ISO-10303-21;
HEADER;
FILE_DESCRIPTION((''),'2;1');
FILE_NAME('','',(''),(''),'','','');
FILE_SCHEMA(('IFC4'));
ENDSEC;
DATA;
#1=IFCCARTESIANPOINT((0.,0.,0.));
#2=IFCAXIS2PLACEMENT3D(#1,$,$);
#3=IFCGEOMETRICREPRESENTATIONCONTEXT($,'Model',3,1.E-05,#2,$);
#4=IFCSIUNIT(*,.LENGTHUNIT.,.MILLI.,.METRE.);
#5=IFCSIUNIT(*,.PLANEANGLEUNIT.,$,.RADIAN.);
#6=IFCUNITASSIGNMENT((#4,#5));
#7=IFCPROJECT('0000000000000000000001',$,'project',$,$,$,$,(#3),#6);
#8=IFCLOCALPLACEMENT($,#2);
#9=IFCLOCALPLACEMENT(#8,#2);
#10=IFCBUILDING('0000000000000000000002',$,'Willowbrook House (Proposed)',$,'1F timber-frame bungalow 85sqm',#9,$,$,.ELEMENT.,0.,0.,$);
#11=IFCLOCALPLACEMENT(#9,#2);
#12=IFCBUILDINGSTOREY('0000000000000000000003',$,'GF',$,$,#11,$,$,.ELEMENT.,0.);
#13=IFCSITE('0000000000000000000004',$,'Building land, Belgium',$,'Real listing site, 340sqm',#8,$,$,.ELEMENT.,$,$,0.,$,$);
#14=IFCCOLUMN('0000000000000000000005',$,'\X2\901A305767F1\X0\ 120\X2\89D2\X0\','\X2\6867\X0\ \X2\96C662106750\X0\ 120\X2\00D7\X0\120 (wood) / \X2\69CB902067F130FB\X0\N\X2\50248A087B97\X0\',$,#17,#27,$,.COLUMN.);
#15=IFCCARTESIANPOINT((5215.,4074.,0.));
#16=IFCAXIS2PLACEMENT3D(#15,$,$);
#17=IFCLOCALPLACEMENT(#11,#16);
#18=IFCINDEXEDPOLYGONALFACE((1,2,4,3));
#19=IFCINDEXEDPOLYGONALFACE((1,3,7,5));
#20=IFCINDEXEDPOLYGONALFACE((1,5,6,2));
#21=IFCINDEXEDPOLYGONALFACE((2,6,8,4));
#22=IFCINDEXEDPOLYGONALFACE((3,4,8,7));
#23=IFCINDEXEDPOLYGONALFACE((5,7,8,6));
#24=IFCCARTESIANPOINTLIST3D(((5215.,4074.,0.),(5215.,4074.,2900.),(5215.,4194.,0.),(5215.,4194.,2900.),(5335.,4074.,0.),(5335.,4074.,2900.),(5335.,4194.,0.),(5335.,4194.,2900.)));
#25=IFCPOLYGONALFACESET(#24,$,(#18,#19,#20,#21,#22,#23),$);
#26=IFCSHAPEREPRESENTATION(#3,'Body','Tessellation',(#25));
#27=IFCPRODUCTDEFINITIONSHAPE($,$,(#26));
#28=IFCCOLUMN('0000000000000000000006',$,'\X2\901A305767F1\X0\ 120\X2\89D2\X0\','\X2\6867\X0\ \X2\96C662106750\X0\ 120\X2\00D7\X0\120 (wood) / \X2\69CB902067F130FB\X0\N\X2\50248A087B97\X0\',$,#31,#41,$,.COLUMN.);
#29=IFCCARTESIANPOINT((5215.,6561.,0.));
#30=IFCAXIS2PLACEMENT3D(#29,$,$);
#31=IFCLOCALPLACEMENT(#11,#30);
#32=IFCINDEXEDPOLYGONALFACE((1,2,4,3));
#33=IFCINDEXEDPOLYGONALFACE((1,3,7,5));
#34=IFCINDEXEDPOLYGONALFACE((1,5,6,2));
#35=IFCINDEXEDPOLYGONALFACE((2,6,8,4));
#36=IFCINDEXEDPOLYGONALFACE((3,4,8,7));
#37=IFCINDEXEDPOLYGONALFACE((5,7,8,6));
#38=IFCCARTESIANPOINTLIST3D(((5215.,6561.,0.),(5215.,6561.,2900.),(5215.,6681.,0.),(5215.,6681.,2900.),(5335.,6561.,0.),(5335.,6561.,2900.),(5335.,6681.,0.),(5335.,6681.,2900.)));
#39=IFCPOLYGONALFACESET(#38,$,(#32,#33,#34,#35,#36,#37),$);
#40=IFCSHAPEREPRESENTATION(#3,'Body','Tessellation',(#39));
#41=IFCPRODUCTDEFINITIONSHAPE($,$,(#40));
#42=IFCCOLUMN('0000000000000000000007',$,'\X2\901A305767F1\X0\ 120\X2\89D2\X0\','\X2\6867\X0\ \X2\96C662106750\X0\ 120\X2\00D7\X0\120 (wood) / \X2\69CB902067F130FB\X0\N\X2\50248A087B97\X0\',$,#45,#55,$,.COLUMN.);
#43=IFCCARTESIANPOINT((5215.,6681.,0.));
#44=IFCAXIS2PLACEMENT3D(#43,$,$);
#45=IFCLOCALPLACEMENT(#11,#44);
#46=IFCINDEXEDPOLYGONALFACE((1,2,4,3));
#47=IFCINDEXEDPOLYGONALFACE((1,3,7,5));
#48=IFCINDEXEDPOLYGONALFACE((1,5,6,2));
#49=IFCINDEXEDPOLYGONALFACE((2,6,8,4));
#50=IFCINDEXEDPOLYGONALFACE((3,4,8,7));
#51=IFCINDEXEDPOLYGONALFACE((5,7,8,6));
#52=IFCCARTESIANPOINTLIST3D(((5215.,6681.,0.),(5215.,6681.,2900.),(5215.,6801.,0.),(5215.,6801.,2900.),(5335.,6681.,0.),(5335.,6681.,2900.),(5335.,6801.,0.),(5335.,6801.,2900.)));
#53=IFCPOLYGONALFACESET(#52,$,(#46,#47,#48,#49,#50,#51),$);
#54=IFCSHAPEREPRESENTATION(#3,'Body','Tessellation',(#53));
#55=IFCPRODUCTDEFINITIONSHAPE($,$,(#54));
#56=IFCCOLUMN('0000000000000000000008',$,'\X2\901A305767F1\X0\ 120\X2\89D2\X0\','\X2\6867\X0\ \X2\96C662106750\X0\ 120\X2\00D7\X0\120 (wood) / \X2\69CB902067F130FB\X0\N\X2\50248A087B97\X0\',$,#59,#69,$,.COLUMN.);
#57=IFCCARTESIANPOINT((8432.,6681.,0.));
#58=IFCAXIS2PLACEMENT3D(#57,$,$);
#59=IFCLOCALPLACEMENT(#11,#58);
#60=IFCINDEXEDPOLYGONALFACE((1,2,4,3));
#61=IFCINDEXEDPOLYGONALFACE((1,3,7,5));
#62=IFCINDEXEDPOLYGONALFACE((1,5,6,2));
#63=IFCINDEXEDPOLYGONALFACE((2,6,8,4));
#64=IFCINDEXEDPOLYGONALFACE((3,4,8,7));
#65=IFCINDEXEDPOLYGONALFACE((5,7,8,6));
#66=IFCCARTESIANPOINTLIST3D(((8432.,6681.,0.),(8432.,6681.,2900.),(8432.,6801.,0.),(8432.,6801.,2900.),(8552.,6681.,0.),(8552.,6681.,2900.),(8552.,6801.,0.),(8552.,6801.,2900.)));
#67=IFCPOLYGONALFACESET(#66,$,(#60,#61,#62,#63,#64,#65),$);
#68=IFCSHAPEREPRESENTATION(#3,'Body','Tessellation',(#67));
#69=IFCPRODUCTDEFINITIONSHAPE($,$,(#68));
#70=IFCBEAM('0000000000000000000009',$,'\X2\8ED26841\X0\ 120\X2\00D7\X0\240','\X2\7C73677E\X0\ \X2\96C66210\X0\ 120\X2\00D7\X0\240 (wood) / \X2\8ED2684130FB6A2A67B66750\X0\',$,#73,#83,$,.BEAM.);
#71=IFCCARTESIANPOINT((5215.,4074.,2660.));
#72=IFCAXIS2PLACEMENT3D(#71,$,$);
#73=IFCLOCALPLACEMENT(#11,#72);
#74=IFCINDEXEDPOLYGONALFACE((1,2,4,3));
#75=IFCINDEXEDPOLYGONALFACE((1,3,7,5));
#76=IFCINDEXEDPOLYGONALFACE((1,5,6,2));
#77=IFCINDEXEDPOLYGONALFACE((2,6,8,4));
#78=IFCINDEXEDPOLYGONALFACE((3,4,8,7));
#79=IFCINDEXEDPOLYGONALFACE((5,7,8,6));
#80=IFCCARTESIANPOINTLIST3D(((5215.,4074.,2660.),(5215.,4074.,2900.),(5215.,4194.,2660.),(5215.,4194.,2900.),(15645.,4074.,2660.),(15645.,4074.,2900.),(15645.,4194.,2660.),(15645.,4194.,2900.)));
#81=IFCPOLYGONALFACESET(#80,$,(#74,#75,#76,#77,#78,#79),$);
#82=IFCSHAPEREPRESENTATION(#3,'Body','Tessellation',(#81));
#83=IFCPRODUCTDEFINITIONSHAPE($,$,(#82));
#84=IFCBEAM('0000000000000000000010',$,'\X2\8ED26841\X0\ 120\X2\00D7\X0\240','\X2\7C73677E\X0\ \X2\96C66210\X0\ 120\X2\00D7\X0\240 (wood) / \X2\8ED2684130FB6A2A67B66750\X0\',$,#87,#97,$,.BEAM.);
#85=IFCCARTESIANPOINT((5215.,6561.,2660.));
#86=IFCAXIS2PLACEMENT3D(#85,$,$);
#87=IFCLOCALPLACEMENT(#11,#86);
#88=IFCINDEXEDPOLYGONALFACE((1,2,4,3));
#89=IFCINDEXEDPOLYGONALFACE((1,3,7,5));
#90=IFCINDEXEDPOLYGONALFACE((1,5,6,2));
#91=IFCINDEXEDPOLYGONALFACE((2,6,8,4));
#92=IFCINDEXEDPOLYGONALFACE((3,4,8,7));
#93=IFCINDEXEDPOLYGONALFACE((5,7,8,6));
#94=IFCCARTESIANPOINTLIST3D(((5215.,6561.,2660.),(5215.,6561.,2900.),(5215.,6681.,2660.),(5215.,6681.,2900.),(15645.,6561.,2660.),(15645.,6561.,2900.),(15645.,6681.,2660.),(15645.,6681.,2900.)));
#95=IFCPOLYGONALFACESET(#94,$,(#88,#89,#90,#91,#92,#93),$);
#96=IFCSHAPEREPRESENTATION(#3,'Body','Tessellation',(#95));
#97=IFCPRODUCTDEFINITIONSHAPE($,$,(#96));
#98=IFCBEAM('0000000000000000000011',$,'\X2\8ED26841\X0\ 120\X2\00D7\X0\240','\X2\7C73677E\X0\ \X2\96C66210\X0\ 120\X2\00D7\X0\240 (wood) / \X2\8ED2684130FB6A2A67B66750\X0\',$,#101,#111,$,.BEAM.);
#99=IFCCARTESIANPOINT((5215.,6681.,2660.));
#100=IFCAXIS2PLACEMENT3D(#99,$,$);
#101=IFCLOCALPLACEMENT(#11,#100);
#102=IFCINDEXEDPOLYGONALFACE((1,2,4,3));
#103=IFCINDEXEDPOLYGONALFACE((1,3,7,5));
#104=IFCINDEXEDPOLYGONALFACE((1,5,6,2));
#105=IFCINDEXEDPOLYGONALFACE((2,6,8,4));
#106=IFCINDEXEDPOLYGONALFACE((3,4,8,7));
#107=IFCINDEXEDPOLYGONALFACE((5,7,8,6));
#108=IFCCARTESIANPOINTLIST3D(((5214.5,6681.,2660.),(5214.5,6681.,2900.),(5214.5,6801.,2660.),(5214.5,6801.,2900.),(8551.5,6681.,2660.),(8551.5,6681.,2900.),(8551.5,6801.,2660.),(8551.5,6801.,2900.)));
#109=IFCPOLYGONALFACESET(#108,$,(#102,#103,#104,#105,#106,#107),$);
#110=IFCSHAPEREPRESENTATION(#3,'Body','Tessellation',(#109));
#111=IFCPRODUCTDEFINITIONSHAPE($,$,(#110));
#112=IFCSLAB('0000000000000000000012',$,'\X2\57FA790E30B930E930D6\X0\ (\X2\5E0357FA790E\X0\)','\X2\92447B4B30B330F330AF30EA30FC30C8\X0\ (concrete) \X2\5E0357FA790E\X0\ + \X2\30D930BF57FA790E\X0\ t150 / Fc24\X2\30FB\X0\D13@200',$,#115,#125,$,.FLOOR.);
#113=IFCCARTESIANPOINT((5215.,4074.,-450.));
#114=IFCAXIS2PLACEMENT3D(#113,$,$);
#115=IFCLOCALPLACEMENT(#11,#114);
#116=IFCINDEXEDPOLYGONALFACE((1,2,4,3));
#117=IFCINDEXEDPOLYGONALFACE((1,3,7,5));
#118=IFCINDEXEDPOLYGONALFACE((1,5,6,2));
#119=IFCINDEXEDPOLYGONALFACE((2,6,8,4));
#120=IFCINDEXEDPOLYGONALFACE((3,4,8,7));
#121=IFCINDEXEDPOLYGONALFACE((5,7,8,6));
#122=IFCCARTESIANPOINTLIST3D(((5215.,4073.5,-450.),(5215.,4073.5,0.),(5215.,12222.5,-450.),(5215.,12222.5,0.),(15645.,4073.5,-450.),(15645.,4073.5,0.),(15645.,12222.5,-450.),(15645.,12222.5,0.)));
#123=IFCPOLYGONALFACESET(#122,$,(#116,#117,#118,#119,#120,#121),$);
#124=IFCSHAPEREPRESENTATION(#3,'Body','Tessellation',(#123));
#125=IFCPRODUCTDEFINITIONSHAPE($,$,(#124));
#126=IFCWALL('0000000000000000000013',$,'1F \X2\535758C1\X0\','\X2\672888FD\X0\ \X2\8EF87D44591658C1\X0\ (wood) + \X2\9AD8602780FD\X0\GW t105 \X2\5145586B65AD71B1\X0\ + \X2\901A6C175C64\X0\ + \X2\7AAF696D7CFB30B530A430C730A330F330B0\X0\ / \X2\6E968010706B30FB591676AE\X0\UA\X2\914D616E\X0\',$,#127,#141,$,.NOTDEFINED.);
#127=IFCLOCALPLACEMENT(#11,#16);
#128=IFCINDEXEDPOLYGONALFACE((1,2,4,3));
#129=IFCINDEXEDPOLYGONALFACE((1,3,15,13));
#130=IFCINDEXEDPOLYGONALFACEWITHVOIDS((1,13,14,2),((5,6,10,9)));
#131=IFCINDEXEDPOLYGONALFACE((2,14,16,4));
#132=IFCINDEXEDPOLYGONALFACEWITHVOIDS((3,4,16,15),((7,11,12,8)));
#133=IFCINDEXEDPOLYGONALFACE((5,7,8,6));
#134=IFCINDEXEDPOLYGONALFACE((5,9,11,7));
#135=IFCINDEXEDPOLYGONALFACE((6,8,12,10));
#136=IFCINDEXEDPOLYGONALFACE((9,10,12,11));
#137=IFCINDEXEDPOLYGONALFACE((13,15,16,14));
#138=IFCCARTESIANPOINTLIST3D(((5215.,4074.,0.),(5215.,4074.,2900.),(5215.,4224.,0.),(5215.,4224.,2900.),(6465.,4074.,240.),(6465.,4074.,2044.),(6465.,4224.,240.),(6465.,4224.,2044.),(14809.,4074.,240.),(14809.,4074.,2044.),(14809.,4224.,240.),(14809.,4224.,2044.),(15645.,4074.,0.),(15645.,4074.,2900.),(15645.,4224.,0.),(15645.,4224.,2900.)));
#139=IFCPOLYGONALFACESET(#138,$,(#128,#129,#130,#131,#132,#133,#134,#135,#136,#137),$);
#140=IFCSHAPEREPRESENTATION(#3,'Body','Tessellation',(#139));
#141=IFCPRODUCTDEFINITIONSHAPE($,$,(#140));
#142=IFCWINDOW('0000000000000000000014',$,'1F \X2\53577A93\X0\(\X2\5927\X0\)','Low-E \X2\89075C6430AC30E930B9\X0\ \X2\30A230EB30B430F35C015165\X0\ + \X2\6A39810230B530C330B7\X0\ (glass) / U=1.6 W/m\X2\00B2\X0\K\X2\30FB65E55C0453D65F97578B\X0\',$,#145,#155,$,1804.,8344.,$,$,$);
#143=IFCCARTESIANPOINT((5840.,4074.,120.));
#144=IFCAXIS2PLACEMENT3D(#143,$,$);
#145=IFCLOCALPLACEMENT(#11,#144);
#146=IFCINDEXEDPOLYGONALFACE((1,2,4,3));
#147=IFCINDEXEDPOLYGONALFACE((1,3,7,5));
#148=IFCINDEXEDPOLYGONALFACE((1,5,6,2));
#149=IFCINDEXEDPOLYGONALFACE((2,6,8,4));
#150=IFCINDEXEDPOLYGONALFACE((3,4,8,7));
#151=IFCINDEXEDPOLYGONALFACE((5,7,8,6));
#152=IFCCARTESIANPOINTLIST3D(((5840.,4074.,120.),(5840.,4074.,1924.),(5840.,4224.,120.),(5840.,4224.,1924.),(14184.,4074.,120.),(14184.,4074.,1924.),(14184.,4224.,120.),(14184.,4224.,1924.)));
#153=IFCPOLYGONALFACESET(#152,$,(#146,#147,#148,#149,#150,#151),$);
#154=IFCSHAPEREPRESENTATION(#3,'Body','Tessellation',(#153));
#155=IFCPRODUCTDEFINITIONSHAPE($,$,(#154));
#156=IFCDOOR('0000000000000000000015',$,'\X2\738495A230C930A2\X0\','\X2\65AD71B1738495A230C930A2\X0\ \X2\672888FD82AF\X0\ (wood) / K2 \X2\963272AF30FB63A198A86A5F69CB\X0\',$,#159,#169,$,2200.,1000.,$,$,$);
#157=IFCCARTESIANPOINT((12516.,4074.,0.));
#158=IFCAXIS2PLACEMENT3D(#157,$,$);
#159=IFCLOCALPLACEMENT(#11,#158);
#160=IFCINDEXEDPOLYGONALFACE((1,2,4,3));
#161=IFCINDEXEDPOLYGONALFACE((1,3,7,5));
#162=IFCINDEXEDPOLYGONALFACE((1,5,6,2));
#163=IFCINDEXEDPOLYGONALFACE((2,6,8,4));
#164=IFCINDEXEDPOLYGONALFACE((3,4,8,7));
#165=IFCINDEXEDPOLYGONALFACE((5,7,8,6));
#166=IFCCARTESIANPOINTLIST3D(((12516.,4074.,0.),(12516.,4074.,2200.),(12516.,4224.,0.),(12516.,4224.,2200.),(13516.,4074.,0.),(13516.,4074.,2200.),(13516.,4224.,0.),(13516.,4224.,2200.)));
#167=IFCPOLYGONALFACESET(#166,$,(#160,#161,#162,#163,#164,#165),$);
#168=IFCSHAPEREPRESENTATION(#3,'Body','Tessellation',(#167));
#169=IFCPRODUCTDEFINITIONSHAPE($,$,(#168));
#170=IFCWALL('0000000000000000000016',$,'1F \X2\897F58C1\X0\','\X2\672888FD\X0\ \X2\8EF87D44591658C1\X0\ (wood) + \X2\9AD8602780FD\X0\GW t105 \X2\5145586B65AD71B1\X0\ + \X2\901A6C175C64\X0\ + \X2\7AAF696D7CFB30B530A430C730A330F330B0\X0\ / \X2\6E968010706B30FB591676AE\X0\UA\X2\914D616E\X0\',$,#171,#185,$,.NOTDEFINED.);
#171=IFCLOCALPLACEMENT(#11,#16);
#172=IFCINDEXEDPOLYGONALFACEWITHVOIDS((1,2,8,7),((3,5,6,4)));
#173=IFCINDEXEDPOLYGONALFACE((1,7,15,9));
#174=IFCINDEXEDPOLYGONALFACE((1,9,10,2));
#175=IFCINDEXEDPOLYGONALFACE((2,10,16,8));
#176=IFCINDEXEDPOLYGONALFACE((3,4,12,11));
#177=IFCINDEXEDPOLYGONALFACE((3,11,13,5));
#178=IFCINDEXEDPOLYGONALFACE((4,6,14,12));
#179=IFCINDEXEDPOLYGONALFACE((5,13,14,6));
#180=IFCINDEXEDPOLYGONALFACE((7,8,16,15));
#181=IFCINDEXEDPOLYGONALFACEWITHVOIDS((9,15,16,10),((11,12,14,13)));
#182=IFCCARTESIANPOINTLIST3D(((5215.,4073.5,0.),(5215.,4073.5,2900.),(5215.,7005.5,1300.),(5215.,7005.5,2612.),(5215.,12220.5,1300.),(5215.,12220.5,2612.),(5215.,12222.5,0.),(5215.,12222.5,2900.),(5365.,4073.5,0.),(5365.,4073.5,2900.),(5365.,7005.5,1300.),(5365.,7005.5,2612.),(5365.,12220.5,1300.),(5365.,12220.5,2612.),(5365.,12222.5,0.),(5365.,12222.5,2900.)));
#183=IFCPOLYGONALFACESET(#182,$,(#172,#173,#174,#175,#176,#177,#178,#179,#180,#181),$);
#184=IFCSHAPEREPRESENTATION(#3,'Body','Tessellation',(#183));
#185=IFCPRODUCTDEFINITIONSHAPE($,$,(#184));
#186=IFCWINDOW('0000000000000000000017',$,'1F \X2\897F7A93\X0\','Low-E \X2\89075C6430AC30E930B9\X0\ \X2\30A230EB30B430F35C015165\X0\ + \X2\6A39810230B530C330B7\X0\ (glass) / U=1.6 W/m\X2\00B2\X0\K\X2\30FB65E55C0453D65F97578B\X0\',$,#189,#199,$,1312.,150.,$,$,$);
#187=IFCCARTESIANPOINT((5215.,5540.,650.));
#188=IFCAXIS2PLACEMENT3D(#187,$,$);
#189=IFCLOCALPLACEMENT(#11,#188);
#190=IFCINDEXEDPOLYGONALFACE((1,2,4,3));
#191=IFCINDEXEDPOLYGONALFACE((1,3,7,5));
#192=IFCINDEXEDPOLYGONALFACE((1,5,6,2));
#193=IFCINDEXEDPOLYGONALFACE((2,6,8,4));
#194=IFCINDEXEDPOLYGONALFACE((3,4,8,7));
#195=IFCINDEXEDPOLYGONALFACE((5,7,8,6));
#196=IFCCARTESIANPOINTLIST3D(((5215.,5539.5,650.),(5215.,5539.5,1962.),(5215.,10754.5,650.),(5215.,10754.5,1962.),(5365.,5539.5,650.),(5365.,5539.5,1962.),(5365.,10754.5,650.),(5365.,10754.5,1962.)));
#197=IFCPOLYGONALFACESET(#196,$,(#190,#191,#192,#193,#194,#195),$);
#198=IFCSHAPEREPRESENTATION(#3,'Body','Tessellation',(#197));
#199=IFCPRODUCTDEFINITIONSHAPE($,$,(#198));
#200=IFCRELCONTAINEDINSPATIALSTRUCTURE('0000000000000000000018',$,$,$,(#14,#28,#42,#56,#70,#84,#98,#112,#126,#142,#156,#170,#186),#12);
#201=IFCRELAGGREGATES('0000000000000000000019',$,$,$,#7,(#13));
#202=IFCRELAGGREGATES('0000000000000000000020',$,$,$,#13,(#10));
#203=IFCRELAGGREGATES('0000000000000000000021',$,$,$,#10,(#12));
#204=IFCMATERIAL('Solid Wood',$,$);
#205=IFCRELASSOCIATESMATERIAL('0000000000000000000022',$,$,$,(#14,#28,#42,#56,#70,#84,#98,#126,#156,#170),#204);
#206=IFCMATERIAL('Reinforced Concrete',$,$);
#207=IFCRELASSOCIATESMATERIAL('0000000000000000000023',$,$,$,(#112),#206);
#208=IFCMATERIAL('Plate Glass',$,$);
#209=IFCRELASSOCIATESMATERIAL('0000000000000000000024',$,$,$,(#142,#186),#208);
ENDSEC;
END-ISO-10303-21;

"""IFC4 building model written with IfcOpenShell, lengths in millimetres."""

from ifc_helpers import new_model, si_unit, frame, frame_2d, origin, place, context, project, spatial, rectangle, extrude, material, element, fill, save


model = new_model("IFC4")

# Units and contexts
model_context = context("Model", 3, precision=1e-05, world=origin())
ifc_project = project(units=[si_unit("LENGTHUNIT", "METRE", prefix="MILLI"), si_unit("PLANEANGLEUNIT", "RADIAN")], contexts=[model_context])

# Site, building, storey
site_placement = place(None, origin())
site = spatial("IfcSite", under=ifc_project, at=site_placement, Name="Building land, Belgium", ObjectType="Real listing site, 340sqm", CompositionType="ELEMENT", RefElevation=0.0)
building_placement = place(site_placement, origin())
building = spatial("IfcBuilding", under=site, at=building_placement, Name="Willowbrook House (Proposed)", ObjectType="1F timber-frame bungalow 85sqm", CompositionType="ELEMENT", ElevationOfRefHeight=0.0, ElevationOfTerrain=0.0)
storey_placement = place(building_placement, origin())
storey = spatial("IfcBuildingStorey", under=building, at=storey_placement, Name="GF", CompositionType="ELEMENT", Elevation=0.0)

# Columns
ifc_material_1 = material(Name="Solid Wood")
column_1_placement = place(storey_placement, frame((5215.0, 4074.0, 0.0)))
element("IfcColumn", 1, at=column_1_placement, inside=storey, material=ifc_material_1, Name="通し柱 120角", Description="桧 集成材 120×120 (wood) / 構造柱・N値計算", PredefinedType="COLUMN", context=model_context, shape_type="SweptSolid", body=[
    extrude(rectangle(XDim=120.0, YDim=120.0, at=frame_2d((60.0, 60.0))), frame((5215.0, 4074.0, 0.0)), (0.0, 0.0, 1.0), 2900.0),
])
column_2_placement = place(storey_placement, frame((5215.0, 6561.0, 0.0)))
element("IfcColumn", 2, at=column_2_placement, inside=storey, material=ifc_material_1, Name="通し柱 120角", Description="桧 集成材 120×120 (wood) / 構造柱・N値計算", PredefinedType="COLUMN", context=model_context, shape_type="SweptSolid", body=[
    extrude(rectangle(XDim=120.0, YDim=120.0, at=frame_2d((60.0, 60.0))), frame((5215.0, 6561.0, 0.0)), (0.0, 0.0, 1.0), 2900.0),
])
column_3_placement = place(storey_placement, frame((5215.0, 6681.0, 0.0)))
element("IfcColumn", 3, at=column_3_placement, inside=storey, material=ifc_material_1, Name="通し柱 120角", Description="桧 集成材 120×120 (wood) / 構造柱・N値計算", PredefinedType="COLUMN", context=model_context, shape_type="SweptSolid", body=[
    extrude(rectangle(XDim=120.0, YDim=120.0, at=frame_2d((60.0, 60.0))), frame((5215.0, 6681.0, 0.0)), (0.0, 0.0, 1.0), 2900.0),
])
column_4_placement = place(storey_placement, frame((8432.0, 6681.0, 0.0)))
element("IfcColumn", 4, at=column_4_placement, inside=storey, material=ifc_material_1, Name="通し柱 120角", Description="桧 集成材 120×120 (wood) / 構造柱・N値計算", PredefinedType="COLUMN", context=model_context, shape_type="SweptSolid", body=[
    extrude(rectangle(XDim=120.0, YDim=120.0, at=frame_2d((60.0, 60.0))), frame((8432.0, 6681.0, 0.0)), (0.0, 0.0, 1.0), 2900.0),
])

# Beams
beam_1_placement = place(storey_placement, frame((5215.0, 4074.0, 2660.0)))
element("IfcBeam", 5, at=beam_1_placement, inside=storey, material=ifc_material_1, Name="軒桁 120×240", Description="米松 集成 120×240 (wood) / 軒桁・横架材", PredefinedType="BEAM", context=model_context, shape_type="SweptSolid", body=[
    extrude(rectangle(XDim=10430.0, YDim=120.0, at=frame_2d((5215.0, 60.0))), frame((5215.0, 4074.0, 2660.0)), (0.0, 0.0, 1.0), 240.0),
])
beam_2_placement = place(storey_placement, frame((5215.0, 6561.0, 2660.0)))
element("IfcBeam", 6, at=beam_2_placement, inside=storey, material=ifc_material_1, Name="軒桁 120×240", Description="米松 集成 120×240 (wood) / 軒桁・横架材", PredefinedType="BEAM", context=model_context, shape_type="SweptSolid", body=[
    extrude(rectangle(XDim=10430.0, YDim=120.0, at=frame_2d((5215.0, 60.0))), frame((5215.0, 6561.0, 2660.0)), (0.0, 0.0, 1.0), 240.0),
])
beam_3_placement = place(storey_placement, frame((5215.0, 6681.0, 2660.0)))
element("IfcBeam", 7, at=beam_3_placement, inside=storey, material=ifc_material_1, Name="軒桁 120×240", Description="米松 集成 120×240 (wood) / 軒桁・横架材", PredefinedType="BEAM", context=model_context, shape_type="SweptSolid", body=[
    extrude(rectangle(XDim=3337.0, YDim=120.0, at=frame_2d((1668.0, 60.0))), frame((5215.0, 6681.0, 2660.0)), (0.0, 0.0, 1.0), 240.0),
])

# Slab
ifc_material_2 = material(Name="Reinforced Concrete")
slab_1_placement = place(storey_placement, frame((5215.0, 4074.0, -450.0)))
element("IfcSlab", 8, at=slab_1_placement, inside=storey, material=ifc_material_2, Name="基礎スラブ (布基礎)", Description="鉄筋コンクリート (concrete) 布基礎 + ベタ基礎 t150 / Fc24・D13@200", PredefinedType="FLOOR", context=model_context, shape_type="SweptSolid", body=[
    extrude(rectangle(XDim=10430.0, YDim=8149.0, at=frame_2d((5215.0, 4074.0))), frame((5215.0, 4074.0, -450.0)), (0.0, 0.0, 1.0), 450.0),
])

# Wall, openings, window, door
wall_1_placement = place(storey_placement, frame((5215.0, 4074.0, 0.0)))
wall_1 = element("IfcWall", 9, at=wall_1_placement, inside=storey, material=ifc_material_1, Name="1F 南壁", Description="木製 軸組外壁 (wood) + 高性能GW t105 充填断熱 + 通気層 + 窯業系サイディング / 準耐火・外皮UA配慮", PredefinedType="NOTDEFINED", context=model_context, shape_type="SweptSolid", body=[
    extrude(rectangle(XDim=10430.0, YDim=150.0, at=frame_2d((5215.0, 75.0))), frame((5215.0, 4074.0, 0.0)), (0.0, 0.0, 1.0), 2900.0),
])
opening_1_placement = place(storey_placement, frame((5840.0, 4074.0, 120.0)))
opening_1 = element("IfcOpeningElement", 10, at=opening_1_placement, cuts=wall_1, PredefinedType="NOTDEFINED", context=model_context, shape_type="SweptSolid", body=[
    extrude(rectangle(XDim=8344.0, YDim=150.0, at=frame_2d((4172.0, 75.0))), frame((5840.0, 4074.0, 120.0)), (0.0, 0.0, 1.0), 1804.0),
])
opening_2_placement = place(storey_placement, frame((12516.0, 4074.0, 0.0)))
opening_2 = element("IfcOpeningElement", 11, at=opening_2_placement, cuts=wall_1, PredefinedType="NOTDEFINED", context=model_context, shape_type="SweptSolid", body=[
    extrude(rectangle(XDim=1000.0, YDim=150.0, at=frame_2d((500.0, 75.0))), frame((12516.0, 4074.0, 0.0)), (0.0, 0.0, 1.0), 2200.0),
])
ifc_material_3 = material(Name="Plate Glass")
window_1_placement = place(storey_placement, frame((5840.0, 4074.0, 120.0)))
window_1 = element("IfcWindow", 12, at=window_1_placement, inside=storey, material=ifc_material_3, Name="1F 南窓(大)", Description="Low-E 複層ガラス アルゴン封入 + 樹脂サッシ (glass) / U=1.6 W/m²K・日射取得型", OverallHeight=1804.0, OverallWidth=8344.0, context=model_context, shape_type="SweptSolid", body=[
    extrude(rectangle(XDim=8344.0, YDim=150.0, at=frame_2d((4172.0, 75.0))), frame((5840.0, 4074.0, 120.0)), (0.0, 0.0, 1.0), 1804.0),
])
fill(opening_1, window_1)
door_placement = place(storey_placement, frame((12516.0, 4074.0, 0.0)))
door = element("IfcDoor", 13, at=door_placement, inside=storey, material=ifc_material_1, Name="玄関ドア", Description="断熱玄関ドア 木製芯 (wood) / K2 防犯・採風機構", OverallHeight=2200.0, OverallWidth=1000.0, context=model_context, shape_type="SweptSolid", body=[
    extrude(rectangle(XDim=1000.0, YDim=150.0, at=frame_2d((500.0, 75.0))), frame((12516.0, 4074.0, 0.0)), (0.0, 0.0, 1.0), 2200.0),
])
fill(opening_2, door)

# Wall, opening, window
wall_2_placement = place(storey_placement, frame((5215.0, 4074.0, 0.0)))
wall_2 = element("IfcWall", 14, at=wall_2_placement, inside=storey, material=ifc_material_1, Name="1F 西壁", Description="木製 軸組外壁 (wood) + 高性能GW t105 充填断熱 + 通気層 + 窯業系サイディング / 準耐火・外皮UA配慮", PredefinedType="NOTDEFINED", context=model_context, shape_type="SweptSolid", body=[
    extrude(rectangle(XDim=150.0, YDim=8149.0, at=frame_2d((75.0, 4074.0))), frame((5215.0, 4074.0, 0.0)), (0.0, 0.0, 1.0), 2900.0),
])
opening_3_placement = place(storey_placement, frame((5215.0, 5540.0, 650.0)))
opening_3 = element("IfcOpeningElement", 15, at=opening_3_placement, cuts=wall_2, PredefinedType="NOTDEFINED", context=model_context, shape_type="SweptSolid", body=[
    extrude(rectangle(XDim=150.0, YDim=5215.0, at=frame_2d((75.0, 2607.0))), frame((5215.0, 5540.0, 650.0)), (0.0, 0.0, 1.0), 1312.0),
])
window_2_placement = place(storey_placement, frame((5215.0, 5540.0, 650.0)))
window_2 = element("IfcWindow", 16, at=window_2_placement, inside=storey, material=ifc_material_3, Name="1F 西窓", Description="Low-E 複層ガラス アルゴン封入 + 樹脂サッシ (glass) / U=1.6 W/m²K・日射取得型", OverallHeight=1312.0, OverallWidth=150.0, context=model_context, shape_type="SweptSolid", body=[
    extrude(rectangle(XDim=150.0, YDim=5215.0, at=frame_2d((75.0, 2607.0))), frame((5215.0, 5540.0, 650.0)), (0.0, 0.0, 1.0), 1312.0),
])
fill(opening_3, window_2)

save(model, "model.ifc")
